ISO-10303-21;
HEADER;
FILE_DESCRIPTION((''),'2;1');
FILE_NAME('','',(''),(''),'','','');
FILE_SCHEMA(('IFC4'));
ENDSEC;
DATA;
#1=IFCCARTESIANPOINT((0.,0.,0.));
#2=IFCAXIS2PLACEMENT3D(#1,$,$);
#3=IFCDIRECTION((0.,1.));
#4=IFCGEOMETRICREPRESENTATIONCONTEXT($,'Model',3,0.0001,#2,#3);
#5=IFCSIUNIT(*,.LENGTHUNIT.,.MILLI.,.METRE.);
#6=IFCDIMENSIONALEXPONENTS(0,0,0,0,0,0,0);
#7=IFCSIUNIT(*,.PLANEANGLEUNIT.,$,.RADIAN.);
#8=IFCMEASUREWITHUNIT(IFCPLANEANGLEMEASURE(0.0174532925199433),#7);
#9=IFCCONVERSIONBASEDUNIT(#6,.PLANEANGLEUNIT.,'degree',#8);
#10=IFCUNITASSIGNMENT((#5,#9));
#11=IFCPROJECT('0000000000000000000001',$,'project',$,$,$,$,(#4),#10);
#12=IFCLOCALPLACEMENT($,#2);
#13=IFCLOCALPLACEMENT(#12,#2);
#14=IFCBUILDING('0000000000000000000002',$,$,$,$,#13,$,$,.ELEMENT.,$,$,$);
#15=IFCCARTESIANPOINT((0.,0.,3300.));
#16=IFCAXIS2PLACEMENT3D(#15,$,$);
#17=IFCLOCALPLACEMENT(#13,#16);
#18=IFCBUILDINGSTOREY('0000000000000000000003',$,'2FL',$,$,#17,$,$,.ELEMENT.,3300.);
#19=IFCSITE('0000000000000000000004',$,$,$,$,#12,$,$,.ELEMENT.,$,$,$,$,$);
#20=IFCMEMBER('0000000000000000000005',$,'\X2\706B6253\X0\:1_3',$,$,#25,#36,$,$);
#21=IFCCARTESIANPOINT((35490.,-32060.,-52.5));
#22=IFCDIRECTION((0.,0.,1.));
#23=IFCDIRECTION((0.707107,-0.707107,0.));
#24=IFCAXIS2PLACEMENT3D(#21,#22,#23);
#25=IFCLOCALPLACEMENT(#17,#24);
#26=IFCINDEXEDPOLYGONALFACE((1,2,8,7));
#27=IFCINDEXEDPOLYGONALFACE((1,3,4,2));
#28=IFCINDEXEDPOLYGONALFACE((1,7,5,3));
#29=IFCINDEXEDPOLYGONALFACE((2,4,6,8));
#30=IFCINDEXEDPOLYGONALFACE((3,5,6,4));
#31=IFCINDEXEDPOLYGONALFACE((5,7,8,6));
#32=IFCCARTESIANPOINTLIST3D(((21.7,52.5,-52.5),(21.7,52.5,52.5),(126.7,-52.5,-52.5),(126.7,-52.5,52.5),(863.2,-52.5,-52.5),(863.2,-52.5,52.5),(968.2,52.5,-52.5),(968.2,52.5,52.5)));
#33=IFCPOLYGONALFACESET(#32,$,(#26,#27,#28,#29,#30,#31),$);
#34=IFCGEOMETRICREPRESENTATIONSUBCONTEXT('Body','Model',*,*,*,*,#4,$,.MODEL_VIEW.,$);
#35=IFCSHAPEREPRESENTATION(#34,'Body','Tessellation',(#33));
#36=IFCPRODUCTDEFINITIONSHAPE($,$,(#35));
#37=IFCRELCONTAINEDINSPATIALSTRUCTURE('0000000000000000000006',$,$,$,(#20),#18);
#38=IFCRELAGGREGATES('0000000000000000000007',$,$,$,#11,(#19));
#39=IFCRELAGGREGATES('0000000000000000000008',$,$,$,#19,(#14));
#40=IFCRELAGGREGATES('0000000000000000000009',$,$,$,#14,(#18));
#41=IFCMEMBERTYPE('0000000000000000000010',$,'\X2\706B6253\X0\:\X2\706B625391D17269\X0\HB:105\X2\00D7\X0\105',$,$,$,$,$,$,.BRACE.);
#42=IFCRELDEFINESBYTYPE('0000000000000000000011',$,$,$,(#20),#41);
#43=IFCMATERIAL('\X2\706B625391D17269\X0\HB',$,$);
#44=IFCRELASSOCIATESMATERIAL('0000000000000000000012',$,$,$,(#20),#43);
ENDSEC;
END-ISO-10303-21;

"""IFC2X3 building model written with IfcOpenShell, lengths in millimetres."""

from ifc_helpers import new_model, entity, si_unit, converted_unit, direction, frame, origin, place, context, subcontext, project, spatial, polyline, outline, extrude, material, type_object, element, save


model = new_model("IFC2X3")

# Units and contexts
model_context = context("Model", 3, precision=0.0001, world=origin(), true_north=direction((0.0, 1.0)))
body_context = subcontext(model_context, "Body", "Model", "MODEL_VIEW")
ifc_project = project(units=[si_unit("LENGTHUNIT", "METRE", prefix="MILLI"), converted_unit("PLANEANGLEUNIT", "degree", entity("IfcPlaneAngleMeasure", 0.0174532925199433), si_unit("PLANEANGLEUNIT", "RADIAN"), dimensions=[0, 0, 0, 0, 0, 0, 0])], contexts=[model_context])

# Site, building, storey
site_placement = place(None, origin())
site = spatial("IfcSite", under=ifc_project, at=site_placement, CompositionType="ELEMENT")
building_placement = place(site_placement, origin())
building = spatial("IfcBuilding", under=site, at=building_placement, CompositionType="ELEMENT")
storey_placement = place(building_placement, frame((0.0, 0.0, 3300.0)))
storey = spatial("IfcBuildingStorey", under=building, at=storey_placement, Name="2FL", CompositionType="ELEMENT", Elevation=3300.0)

# Member
ifc_material = material(Name="火打金物HB")
member_type_1 = type_object("IfcMemberType", Name="火打:火打金物HB:105×105", PredefinedType="BRACE")
member_1_placement = place(storey_placement, frame((35490.0, -32060.0, -52.5), z_axis=(0.0, 0.0, 1.0), x_axis=(0.707107, -0.707107, 0.0)))
element("IfcMember", 1, at=member_1_placement, inside=storey, type_object=member_type_1, material=ifc_material, Name="火打:1_3", context=body_context, shape_type="SweptSolid", body=[
    extrude(outline(polyline([(126.7, -52.5, 0.0), (21.7, 52.5, 0.0), (968.2, 52.5, 0.0), (863.2, -52.5, 0.0), (126.7, -52.5, 0.0)])), frame((0.0, 0.0, -52.5), z_axis=(0.0, 0.0, 1.0), x_axis=(1.0, 0.0, 0.0)), (0.0, 0.0, 1.0), 105.0),
])

save(model, "model.ifc")
